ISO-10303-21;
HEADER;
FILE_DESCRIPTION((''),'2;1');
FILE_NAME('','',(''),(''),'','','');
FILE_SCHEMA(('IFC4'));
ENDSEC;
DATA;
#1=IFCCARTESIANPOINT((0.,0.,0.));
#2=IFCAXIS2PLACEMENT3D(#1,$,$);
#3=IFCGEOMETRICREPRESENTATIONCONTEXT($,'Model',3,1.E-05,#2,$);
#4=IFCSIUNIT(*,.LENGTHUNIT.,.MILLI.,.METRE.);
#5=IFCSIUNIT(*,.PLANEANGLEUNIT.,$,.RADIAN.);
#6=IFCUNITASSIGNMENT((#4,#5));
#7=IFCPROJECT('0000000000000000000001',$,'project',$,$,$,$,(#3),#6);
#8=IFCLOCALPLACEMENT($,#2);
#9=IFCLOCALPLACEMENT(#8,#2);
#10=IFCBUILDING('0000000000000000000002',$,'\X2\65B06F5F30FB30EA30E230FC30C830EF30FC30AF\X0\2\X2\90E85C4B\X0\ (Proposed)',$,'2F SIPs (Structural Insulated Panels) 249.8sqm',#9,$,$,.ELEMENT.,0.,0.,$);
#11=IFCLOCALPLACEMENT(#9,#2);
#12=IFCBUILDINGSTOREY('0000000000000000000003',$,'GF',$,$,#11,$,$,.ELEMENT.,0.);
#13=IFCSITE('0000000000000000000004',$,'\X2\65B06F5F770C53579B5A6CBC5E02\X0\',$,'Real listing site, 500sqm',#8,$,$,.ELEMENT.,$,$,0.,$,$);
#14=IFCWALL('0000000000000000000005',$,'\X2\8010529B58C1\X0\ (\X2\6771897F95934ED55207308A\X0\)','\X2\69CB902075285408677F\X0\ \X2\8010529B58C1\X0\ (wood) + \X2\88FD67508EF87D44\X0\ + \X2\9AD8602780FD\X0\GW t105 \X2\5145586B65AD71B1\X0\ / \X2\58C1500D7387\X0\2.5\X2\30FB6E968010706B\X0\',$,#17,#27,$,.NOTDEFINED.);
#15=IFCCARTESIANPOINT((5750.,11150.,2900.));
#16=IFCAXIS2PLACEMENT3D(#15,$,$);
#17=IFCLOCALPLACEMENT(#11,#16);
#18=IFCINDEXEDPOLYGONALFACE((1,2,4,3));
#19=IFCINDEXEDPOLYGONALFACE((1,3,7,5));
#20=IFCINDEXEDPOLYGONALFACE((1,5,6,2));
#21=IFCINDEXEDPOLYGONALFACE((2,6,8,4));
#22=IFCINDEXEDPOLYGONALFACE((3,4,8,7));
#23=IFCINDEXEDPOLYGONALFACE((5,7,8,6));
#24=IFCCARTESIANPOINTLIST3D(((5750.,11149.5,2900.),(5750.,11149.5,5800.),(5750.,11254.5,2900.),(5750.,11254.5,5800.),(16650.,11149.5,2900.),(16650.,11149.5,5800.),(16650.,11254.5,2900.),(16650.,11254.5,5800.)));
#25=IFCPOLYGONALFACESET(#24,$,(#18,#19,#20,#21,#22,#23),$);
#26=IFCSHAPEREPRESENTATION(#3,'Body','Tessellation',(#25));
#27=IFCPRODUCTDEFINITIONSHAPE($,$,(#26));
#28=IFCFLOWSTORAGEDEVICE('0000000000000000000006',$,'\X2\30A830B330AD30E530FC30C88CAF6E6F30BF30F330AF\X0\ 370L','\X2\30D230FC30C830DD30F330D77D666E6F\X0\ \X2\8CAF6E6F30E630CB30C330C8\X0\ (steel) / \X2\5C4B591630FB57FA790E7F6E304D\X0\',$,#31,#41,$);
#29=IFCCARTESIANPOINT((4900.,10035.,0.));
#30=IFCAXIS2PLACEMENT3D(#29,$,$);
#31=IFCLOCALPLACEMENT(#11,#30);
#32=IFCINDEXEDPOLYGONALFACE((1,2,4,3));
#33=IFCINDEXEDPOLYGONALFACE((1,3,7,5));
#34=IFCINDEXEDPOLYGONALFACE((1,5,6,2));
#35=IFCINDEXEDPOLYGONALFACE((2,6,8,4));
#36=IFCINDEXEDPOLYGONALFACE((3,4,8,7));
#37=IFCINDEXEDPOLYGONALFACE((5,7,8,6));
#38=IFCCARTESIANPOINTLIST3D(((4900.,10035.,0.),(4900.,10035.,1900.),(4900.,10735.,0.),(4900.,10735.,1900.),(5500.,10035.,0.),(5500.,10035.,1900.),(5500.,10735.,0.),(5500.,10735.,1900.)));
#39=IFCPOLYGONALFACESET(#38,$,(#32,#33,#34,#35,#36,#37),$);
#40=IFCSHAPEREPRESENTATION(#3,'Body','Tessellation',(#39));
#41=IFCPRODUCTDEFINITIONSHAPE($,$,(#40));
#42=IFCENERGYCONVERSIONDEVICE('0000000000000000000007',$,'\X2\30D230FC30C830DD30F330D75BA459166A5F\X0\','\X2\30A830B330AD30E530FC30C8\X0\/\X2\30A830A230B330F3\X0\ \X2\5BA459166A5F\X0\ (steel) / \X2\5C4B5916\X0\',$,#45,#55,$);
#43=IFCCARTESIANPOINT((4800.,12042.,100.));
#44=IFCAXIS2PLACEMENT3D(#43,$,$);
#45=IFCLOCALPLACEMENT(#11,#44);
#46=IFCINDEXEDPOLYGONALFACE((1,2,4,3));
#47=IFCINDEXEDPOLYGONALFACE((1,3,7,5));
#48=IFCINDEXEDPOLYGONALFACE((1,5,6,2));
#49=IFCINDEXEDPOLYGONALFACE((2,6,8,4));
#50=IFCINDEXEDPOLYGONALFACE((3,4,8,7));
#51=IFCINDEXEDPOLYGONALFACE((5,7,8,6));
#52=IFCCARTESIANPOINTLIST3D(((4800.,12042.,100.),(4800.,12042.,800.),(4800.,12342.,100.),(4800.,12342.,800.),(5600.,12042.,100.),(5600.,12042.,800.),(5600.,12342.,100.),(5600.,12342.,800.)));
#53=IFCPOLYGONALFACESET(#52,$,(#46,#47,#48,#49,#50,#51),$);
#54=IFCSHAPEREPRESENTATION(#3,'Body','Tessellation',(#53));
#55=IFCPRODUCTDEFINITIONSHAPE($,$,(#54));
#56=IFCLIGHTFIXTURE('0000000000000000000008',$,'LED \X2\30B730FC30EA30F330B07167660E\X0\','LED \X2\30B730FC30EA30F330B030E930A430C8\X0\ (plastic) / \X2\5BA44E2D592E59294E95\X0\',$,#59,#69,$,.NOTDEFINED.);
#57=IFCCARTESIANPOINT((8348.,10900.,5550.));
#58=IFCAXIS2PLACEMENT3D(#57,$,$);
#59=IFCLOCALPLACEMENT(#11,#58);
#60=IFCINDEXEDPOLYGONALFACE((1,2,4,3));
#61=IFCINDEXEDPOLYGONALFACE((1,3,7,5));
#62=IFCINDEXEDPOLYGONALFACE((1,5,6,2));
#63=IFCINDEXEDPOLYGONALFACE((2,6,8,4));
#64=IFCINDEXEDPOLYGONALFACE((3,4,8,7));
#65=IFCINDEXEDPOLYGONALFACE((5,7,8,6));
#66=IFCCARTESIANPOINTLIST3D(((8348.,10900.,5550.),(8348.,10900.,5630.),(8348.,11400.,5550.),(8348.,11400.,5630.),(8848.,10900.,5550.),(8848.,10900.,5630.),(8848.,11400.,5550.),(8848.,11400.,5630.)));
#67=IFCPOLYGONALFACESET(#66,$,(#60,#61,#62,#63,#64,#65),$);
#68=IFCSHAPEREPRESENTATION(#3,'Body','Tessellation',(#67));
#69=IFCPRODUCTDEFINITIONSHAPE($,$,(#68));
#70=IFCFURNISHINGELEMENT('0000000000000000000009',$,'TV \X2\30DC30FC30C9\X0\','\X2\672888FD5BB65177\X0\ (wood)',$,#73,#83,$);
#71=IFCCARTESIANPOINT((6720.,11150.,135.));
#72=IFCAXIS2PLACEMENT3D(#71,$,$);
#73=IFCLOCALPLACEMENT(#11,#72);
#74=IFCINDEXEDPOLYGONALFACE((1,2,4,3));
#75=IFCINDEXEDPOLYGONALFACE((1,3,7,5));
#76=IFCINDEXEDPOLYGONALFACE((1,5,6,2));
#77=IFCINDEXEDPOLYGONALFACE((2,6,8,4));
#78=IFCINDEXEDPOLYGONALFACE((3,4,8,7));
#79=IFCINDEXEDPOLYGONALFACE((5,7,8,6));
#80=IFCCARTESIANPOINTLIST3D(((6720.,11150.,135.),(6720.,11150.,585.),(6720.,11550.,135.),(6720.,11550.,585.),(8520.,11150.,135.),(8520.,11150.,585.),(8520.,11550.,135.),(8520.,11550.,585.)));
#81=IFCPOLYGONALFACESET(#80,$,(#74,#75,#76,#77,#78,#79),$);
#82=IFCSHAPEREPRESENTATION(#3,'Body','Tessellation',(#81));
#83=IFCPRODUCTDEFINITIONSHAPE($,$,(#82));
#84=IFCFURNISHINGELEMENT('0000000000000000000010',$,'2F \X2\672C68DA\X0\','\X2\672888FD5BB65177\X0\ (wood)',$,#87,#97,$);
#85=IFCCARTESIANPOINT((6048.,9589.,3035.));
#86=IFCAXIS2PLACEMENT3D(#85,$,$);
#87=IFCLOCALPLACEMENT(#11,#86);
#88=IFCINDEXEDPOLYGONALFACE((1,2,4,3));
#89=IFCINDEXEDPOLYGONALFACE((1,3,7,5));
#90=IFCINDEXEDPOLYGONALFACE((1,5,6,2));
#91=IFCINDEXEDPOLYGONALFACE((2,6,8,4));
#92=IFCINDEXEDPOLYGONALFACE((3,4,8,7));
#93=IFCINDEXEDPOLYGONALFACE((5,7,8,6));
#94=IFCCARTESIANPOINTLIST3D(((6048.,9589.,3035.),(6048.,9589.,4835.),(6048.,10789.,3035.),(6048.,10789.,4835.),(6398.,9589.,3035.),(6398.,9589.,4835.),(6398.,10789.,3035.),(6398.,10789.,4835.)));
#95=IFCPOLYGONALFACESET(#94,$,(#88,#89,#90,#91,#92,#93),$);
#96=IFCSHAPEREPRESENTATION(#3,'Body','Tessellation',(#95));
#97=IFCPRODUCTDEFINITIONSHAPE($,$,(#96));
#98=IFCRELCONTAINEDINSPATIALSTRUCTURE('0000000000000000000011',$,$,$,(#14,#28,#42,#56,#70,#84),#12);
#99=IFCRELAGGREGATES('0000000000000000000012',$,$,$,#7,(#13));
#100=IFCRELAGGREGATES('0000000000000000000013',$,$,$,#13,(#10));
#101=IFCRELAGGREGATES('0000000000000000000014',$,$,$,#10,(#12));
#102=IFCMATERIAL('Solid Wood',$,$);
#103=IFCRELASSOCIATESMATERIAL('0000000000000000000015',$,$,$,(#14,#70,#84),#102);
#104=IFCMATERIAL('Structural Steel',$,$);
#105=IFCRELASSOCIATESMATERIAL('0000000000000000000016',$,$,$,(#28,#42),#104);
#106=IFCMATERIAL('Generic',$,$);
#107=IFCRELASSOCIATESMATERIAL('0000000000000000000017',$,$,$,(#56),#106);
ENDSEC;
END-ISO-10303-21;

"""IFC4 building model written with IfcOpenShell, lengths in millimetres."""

from ifc_helpers import new_model, si_unit, frame, frame_2d, origin, place, context, project, spatial, rectangle, extrude, material, element, save


model = new_model("IFC4")

# Units and contexts
model_context = context("Model", 3, precision=1e-05, world=origin())
ifc_project = project(units=[si_unit("LENGTHUNIT", "METRE", prefix="MILLI"), si_unit("PLANEANGLEUNIT", "RADIAN")], contexts=[model_context])

# Site, building, storey
site_placement = place(None, origin())
site = spatial("IfcSite", under=ifc_project, at=site_placement, Name="新潟県南魚沼市", ObjectType="Real listing site, 500sqm", CompositionType="ELEMENT", RefElevation=0.0)
building_placement = place(site_placement, origin())
building = spatial("IfcBuilding", under=site, at=building_placement, Name="新潟・リモートワーク2部屋 (Proposed)", ObjectType="2F SIPs (Structural Insulated Panels) 249.8sqm", CompositionType="ELEMENT", ElevationOfRefHeight=0.0, ElevationOfTerrain=0.0)
storey_placement = place(building_placement, origin())
storey = spatial("IfcBuildingStorey", under=building, at=storey_placement, Name="GF", CompositionType="ELEMENT", Elevation=0.0)

# Shared definitions
ifc_material_1 = material(Name="Solid Wood")

# Wall
wall_1_placement = place(storey_placement, frame((5750.0, 11150.0, 2900.0)))
element("IfcWall", 1, at=wall_1_placement, inside=storey, material=ifc_material_1, Name="耐力壁 (東西間仕切り)", Description="構造用合板 耐力壁 (wood) + 製材軸組 + 高性能GW t105 充填断熱 / 壁倍率2.5・準耐火", PredefinedType="NOTDEFINED", context=model_context, shape_type="SweptSolid", body=[
    extrude(rectangle(XDim=10900.0, YDim=105.0, at=frame_2d((5450.0, 52.0))), frame((5750.0, 11150.0, 2900.0)), (0.0, 0.0, 1.0), 2900.0),
])

# Flow storage device
ifc_material_2 = material(Name="Structural Steel")
flow_storage_device_placement = place(storey_placement, frame((4900.0, 10035.0, 0.0)))
element("IfcFlowStorageDevice", 2, at=flow_storage_device_placement, inside=storey, material=ifc_material_2, Name="エコキュート貯湯タンク 370L", Description="ヒートポンプ給湯 貯湯ユニット (steel) / 屋外・基礎置き", context=model_context, shape_type="SweptSolid", body=[
    extrude(rectangle(XDim=600.0, YDim=700.0, at=frame_2d((300.0, 350.0))), frame((4900.0, 10035.0, 0.0)), (0.0, 0.0, 1.0), 1900.0),
])

# Energy conversion device
energy_conversion_device_placement = place(storey_placement, frame((4800.0, 12042.0, 100.0)))
element("IfcEnergyConversionDevice", 3, at=energy_conversion_device_placement, inside=storey, material=ifc_material_2, Name="ヒートポンプ室外機", Description="エコキュート/エアコン 室外機 (steel) / 屋外", context=model_context, shape_type="SweptSolid", body=[
    extrude(rectangle(XDim=800.0, YDim=300.0, at=frame_2d((400.0, 150.0))), frame((4800.0, 12042.0, 100.0)), (0.0, 0.0, 1.0), 700.0),
])

# Light fixture
ifc_material_3 = material(Name="Generic")
light_fixture_placement = place(storey_placement, frame((8348.0, 10900.0, 5550.0)))
element("IfcLightFixture", 4, at=light_fixture_placement, inside=storey, material=ifc_material_3, Name="LED シーリング照明", Description="LED シーリングライト (plastic) / 室中央天井", PredefinedType="NOTDEFINED", context=model_context, shape_type="SweptSolid", body=[
    extrude(rectangle(XDim=500.0, YDim=500.0, at=frame_2d((250.0, 250.0))), frame((8348.0, 10900.0, 5550.0)), (0.0, 0.0, 1.0), 80.0),
])

# Furnishing elements
furnishing_1_placement = place(storey_placement, frame((6720.0, 11150.0, 135.0)))
element("IfcFurnishingElement", 5, at=furnishing_1_placement, inside=storey, material=ifc_material_1, Name="TV ボード", Description="木製家具 (wood)", context=model_context, shape_type="SweptSolid", body=[
    extrude(rectangle(XDim=1800.0, YDim=400.0, at=frame_2d((900.0, 200.0))), frame((6720.0, 11150.0, 135.0)), (0.0, 0.0, 1.0), 450.0),
])
furnishing_2_placement = place(storey_placement, frame((6048.0, 9589.0, 3035.0)))
element("IfcFurnishingElement", 6, at=furnishing_2_placement, inside=storey, material=ifc_material_1, Name="2F 本棚", Description="木製家具 (wood)", context=model_context, shape_type="SweptSolid", body=[
    extrude(rectangle(XDim=350.0, YDim=1200.0, at=frame_2d((175.0, 600.0))), frame((6048.0, 9589.0, 3035.0)), (0.0, 0.0, 1.0), 1800.0),
])

save(model, "model.ifc")
